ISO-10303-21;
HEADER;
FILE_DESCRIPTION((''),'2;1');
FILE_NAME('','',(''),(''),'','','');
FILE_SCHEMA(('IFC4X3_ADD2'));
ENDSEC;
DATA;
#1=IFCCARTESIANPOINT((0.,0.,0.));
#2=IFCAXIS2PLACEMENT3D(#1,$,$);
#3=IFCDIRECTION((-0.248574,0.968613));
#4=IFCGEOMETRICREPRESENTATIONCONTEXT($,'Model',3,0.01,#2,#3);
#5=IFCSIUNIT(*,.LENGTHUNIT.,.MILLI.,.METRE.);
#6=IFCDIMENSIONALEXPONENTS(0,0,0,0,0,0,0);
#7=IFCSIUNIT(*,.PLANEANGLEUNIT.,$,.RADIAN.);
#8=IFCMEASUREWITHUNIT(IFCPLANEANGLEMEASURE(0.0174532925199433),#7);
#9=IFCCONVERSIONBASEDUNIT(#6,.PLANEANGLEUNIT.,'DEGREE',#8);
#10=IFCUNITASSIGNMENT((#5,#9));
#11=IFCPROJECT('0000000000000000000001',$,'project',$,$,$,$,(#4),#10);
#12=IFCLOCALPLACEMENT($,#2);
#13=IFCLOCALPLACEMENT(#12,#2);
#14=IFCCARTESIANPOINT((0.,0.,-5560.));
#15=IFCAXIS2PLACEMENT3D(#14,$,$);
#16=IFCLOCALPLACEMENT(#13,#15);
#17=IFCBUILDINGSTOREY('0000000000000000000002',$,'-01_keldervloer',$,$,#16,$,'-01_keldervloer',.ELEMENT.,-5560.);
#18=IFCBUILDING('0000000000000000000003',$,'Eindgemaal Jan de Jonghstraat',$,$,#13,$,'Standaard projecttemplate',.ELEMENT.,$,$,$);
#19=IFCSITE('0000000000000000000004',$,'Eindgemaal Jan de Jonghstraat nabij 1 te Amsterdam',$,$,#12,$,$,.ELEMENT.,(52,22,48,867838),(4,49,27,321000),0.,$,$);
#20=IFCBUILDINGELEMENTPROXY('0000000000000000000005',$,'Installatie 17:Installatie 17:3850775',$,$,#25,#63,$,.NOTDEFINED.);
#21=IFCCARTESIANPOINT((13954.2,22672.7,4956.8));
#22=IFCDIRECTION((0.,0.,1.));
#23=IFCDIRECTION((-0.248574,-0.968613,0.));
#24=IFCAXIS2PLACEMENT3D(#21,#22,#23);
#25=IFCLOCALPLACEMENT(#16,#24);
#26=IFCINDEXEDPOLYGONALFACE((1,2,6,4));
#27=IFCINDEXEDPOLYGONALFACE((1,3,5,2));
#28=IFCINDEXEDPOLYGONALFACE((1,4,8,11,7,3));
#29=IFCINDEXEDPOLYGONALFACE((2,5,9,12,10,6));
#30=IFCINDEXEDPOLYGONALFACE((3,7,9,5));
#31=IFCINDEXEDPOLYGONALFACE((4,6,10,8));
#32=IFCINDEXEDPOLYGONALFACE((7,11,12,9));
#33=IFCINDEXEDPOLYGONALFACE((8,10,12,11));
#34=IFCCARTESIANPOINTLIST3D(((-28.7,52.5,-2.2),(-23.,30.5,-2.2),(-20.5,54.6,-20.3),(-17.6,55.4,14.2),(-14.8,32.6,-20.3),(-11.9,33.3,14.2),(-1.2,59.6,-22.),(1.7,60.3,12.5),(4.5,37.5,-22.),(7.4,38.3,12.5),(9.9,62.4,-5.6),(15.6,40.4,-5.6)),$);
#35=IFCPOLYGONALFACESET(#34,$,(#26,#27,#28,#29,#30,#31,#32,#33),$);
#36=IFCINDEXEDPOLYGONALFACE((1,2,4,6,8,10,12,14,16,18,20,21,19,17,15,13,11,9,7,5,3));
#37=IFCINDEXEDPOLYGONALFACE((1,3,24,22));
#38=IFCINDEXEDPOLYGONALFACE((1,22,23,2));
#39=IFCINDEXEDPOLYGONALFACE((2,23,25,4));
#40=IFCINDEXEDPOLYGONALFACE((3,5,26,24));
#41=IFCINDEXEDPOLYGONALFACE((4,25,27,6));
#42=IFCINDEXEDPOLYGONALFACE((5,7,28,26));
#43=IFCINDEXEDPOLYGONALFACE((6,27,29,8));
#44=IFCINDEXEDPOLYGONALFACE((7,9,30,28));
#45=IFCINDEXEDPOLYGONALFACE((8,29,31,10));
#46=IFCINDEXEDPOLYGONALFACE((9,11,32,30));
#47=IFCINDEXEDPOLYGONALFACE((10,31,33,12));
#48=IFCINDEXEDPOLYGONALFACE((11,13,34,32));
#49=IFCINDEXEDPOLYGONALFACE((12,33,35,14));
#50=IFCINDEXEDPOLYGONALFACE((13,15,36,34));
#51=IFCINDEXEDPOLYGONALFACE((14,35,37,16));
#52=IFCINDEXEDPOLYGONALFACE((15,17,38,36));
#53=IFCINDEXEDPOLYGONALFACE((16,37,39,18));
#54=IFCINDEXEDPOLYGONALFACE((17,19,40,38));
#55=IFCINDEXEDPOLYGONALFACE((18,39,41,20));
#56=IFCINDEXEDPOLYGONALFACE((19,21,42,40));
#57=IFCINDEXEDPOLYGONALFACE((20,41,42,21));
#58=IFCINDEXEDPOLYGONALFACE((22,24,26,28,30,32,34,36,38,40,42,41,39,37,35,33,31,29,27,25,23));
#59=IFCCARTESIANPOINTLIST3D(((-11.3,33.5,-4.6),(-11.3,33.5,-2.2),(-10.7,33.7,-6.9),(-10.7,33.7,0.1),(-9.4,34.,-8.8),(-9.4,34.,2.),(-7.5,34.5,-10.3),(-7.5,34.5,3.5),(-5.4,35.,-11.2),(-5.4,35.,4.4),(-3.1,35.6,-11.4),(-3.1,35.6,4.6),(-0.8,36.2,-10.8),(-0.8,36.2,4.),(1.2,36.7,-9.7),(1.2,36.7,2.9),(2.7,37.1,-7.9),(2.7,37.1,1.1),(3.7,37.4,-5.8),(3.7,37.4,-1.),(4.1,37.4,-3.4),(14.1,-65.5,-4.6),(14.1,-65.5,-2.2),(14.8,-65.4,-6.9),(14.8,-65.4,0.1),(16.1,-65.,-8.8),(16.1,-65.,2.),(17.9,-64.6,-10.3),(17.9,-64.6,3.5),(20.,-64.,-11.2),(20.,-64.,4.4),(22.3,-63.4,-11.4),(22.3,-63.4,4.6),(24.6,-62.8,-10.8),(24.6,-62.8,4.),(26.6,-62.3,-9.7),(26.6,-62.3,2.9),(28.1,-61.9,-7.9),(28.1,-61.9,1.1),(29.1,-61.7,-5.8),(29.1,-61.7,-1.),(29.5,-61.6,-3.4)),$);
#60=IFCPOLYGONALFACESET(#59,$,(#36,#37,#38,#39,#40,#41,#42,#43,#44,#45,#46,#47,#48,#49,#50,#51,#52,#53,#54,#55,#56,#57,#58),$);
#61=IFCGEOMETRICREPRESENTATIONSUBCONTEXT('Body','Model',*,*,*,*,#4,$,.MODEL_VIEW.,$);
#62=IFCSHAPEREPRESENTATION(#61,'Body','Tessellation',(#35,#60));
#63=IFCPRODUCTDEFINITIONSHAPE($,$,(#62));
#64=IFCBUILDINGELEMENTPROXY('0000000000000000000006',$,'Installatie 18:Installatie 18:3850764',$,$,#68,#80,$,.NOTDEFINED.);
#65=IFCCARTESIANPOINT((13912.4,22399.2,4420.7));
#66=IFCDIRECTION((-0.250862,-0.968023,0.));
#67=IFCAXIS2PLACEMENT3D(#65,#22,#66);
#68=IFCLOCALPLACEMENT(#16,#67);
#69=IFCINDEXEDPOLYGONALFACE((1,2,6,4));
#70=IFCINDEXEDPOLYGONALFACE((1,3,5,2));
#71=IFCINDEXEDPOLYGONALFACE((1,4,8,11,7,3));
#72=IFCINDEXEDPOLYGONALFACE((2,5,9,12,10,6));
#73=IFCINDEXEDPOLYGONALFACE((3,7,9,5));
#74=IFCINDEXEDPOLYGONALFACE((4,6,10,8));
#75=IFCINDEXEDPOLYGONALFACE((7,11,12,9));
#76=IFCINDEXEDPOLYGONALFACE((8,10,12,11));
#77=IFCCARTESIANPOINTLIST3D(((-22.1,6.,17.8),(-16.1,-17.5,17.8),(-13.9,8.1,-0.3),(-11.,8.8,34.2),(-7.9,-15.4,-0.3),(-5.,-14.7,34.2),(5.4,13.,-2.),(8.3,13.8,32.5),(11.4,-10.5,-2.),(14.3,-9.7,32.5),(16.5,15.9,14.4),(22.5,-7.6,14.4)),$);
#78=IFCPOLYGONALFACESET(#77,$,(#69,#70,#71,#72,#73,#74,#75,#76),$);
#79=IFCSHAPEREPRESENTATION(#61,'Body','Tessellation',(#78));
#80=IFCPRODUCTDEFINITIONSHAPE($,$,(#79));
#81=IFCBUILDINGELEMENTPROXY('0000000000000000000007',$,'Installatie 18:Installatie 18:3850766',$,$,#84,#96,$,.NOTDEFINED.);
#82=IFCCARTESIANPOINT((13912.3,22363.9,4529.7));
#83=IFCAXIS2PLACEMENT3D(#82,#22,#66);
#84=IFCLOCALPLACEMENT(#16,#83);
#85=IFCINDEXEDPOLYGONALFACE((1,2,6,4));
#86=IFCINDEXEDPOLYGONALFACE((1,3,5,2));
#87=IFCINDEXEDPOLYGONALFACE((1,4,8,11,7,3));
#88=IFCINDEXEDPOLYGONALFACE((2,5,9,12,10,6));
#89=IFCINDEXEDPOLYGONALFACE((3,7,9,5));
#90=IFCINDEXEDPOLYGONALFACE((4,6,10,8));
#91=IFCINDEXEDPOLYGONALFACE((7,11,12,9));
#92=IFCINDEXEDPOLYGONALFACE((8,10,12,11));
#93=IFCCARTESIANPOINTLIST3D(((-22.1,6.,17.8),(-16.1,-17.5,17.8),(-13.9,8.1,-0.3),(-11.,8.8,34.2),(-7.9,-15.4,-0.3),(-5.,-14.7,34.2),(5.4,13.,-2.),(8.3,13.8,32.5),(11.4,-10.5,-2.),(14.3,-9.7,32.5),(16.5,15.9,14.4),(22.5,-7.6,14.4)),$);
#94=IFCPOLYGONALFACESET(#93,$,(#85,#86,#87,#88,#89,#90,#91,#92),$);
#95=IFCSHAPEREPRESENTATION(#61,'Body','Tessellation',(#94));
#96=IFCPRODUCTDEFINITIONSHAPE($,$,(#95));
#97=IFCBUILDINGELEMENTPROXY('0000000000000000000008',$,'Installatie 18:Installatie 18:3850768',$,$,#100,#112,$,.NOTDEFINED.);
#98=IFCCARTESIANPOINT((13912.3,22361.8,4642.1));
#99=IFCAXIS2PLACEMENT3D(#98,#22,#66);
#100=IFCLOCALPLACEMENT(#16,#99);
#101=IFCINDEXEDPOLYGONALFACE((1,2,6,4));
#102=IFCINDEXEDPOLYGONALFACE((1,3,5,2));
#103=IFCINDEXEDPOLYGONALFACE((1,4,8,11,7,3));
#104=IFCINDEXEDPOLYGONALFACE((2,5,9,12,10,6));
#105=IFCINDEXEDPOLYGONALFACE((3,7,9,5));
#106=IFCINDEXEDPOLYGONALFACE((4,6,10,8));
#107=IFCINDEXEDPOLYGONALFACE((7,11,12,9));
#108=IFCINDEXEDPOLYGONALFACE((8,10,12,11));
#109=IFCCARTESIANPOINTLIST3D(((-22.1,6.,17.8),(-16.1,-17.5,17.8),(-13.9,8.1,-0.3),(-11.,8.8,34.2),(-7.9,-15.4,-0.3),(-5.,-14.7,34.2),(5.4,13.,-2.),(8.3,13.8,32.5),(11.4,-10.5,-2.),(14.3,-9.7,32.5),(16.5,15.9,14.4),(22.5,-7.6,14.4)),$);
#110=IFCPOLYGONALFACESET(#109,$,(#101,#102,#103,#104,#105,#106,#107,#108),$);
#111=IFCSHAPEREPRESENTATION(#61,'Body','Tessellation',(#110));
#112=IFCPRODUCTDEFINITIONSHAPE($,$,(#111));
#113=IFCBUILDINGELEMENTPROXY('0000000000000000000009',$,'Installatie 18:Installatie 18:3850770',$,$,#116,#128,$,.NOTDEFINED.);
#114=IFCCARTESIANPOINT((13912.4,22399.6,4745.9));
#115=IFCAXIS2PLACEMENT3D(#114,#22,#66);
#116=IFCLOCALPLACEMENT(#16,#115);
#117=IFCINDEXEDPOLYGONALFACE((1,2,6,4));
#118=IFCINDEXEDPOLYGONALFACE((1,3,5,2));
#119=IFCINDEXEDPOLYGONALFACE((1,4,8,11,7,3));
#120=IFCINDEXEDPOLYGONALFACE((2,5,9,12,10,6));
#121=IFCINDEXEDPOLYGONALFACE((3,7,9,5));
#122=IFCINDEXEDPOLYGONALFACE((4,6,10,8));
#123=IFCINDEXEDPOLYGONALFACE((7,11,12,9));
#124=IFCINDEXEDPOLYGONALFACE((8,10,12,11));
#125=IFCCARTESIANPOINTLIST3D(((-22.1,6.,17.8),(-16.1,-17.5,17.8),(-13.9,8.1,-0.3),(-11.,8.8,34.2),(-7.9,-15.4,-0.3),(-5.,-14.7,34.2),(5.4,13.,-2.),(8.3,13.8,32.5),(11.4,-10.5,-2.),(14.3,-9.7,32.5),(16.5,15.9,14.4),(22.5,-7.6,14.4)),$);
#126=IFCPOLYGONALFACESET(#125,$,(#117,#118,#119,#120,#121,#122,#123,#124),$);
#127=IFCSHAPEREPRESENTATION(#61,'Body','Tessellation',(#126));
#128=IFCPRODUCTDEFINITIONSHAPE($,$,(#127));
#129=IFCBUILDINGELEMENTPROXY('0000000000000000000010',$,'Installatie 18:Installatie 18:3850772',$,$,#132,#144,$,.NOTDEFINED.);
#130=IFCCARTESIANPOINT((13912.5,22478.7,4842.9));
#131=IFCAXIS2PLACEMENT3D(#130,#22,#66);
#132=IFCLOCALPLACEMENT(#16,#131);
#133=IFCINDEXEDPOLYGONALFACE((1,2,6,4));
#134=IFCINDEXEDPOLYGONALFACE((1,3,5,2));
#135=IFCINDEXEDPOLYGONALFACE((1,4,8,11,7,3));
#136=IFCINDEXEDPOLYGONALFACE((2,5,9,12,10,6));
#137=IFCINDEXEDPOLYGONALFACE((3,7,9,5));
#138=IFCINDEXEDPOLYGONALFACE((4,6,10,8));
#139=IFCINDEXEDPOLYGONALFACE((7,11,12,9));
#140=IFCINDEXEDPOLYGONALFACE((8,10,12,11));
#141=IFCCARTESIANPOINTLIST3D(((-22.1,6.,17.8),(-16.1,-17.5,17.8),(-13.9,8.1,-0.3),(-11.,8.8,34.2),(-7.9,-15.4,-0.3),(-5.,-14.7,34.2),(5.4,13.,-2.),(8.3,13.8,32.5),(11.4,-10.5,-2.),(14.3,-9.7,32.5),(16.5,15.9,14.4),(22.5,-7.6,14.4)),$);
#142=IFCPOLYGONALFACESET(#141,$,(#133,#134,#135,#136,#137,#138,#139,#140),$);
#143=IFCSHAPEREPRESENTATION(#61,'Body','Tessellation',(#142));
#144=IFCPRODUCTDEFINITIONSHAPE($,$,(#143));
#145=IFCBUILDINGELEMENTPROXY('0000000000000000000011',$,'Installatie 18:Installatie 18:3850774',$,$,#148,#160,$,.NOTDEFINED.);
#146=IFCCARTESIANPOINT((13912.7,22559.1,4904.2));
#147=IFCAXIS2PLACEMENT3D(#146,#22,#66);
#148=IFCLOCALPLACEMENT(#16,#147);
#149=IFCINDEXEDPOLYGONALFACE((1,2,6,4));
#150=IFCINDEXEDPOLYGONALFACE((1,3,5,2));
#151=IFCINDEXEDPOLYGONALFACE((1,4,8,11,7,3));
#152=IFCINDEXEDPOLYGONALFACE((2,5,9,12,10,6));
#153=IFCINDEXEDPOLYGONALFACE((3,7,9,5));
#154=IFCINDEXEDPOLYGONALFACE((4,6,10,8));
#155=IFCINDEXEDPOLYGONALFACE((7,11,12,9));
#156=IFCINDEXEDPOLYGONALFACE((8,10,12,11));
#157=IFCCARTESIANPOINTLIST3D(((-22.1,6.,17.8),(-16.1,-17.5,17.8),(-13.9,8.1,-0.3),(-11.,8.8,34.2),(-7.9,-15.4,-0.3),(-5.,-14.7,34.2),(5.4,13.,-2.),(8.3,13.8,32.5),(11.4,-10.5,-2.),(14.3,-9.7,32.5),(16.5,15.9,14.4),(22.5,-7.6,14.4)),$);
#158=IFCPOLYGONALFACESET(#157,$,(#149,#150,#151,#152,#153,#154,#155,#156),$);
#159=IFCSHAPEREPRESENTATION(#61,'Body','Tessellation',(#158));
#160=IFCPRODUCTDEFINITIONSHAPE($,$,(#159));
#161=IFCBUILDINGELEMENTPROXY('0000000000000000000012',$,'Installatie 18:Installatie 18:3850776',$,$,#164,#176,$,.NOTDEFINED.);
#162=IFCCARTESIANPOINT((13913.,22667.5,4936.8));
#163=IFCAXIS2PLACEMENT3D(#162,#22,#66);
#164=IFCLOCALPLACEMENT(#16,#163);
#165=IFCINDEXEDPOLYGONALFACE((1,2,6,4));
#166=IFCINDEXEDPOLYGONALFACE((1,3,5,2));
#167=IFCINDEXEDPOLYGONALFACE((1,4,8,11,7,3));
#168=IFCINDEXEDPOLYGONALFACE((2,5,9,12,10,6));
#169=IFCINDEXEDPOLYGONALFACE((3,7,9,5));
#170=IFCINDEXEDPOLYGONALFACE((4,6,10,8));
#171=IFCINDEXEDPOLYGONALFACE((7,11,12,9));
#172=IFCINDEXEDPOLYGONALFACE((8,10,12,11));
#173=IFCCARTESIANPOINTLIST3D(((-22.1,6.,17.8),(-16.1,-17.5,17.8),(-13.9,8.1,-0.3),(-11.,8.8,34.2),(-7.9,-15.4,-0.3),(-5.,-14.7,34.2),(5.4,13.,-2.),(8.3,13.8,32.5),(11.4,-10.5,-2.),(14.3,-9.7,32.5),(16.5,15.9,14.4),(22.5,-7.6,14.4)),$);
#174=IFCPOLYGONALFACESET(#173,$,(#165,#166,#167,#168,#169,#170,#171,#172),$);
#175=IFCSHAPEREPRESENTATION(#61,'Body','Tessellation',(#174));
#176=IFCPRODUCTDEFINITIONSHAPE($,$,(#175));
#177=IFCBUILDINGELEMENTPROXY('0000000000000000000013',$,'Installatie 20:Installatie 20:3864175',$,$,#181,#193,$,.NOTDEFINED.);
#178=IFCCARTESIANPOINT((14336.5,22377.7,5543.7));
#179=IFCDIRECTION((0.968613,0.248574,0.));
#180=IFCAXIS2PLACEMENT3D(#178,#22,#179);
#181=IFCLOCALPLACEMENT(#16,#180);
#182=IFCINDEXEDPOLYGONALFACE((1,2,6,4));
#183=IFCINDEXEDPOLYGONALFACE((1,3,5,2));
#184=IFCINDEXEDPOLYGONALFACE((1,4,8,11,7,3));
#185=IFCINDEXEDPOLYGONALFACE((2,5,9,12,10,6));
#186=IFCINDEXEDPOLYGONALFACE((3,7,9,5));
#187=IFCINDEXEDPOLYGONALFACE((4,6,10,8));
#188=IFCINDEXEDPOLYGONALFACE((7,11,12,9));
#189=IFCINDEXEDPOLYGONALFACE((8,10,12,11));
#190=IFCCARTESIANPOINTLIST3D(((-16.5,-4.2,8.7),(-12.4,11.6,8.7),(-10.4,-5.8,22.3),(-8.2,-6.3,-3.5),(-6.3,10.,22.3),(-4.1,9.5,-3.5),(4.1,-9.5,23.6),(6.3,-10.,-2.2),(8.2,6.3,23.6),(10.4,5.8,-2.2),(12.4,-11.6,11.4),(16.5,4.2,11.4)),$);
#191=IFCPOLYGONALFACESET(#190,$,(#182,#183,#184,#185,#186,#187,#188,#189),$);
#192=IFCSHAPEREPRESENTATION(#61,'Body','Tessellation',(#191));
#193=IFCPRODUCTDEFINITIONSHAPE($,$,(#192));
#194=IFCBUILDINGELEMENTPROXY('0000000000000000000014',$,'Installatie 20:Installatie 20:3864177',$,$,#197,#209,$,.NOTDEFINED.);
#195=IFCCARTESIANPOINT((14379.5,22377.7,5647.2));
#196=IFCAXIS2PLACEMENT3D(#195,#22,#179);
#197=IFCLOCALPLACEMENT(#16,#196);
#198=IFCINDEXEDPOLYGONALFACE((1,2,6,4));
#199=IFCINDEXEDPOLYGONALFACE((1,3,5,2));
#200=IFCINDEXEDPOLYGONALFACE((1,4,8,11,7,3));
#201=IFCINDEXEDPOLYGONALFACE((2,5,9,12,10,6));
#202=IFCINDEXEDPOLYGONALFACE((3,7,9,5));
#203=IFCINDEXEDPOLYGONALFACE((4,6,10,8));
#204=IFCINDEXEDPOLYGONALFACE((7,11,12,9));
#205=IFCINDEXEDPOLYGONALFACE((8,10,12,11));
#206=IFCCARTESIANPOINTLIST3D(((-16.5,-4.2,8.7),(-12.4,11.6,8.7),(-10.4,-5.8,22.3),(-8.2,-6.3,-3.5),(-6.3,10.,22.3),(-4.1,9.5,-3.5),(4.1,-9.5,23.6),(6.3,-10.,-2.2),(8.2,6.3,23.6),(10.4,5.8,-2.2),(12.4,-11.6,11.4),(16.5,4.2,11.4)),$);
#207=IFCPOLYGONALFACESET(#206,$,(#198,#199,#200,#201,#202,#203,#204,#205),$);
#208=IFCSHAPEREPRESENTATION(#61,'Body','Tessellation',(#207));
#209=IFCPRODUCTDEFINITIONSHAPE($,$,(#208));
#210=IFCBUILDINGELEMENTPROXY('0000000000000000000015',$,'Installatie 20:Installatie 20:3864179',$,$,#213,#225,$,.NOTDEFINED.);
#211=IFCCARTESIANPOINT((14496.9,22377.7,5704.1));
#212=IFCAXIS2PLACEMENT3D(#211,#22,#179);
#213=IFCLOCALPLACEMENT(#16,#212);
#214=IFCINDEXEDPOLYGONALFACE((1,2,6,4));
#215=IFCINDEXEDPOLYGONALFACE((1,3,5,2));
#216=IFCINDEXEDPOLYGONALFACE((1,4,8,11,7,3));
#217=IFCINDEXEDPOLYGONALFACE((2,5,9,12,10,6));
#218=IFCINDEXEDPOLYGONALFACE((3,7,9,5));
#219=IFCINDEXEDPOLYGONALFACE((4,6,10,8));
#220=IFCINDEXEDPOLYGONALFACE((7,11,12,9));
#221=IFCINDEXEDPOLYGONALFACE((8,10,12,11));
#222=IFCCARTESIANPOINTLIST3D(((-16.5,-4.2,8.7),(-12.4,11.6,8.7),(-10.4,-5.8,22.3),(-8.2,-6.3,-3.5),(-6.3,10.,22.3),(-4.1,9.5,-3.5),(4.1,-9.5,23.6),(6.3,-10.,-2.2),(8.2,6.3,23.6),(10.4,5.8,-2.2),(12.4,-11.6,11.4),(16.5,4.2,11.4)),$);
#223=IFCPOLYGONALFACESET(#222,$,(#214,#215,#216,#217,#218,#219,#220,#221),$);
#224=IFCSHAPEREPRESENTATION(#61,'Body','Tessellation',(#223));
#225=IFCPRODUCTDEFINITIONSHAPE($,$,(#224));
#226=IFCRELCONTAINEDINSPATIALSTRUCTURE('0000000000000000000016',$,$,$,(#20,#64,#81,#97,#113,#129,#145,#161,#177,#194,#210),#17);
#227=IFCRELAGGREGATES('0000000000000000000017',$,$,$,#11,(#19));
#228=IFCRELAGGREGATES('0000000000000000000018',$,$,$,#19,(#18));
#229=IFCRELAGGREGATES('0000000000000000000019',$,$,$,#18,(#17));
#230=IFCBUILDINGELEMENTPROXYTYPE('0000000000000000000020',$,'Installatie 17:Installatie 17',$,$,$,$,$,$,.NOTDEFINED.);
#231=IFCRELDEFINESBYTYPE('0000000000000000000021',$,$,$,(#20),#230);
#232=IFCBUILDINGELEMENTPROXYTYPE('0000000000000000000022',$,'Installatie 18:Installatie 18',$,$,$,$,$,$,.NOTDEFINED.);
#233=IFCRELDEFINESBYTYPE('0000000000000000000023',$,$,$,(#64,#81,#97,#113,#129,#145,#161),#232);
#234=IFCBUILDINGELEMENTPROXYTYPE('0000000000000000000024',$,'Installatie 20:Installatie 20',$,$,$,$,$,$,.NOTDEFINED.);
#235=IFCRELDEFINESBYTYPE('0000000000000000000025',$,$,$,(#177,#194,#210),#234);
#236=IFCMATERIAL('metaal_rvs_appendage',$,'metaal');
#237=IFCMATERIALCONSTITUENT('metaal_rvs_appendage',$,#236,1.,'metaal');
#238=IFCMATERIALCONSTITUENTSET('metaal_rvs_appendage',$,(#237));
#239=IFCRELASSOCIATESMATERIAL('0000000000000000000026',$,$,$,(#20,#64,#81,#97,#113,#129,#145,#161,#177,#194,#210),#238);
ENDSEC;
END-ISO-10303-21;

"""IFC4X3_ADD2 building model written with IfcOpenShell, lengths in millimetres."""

from ifc_helpers import new_model, entity, si_unit, converted_unit, direction, frame, frame_2d, origin, place, context, subcontext, project, spatial, polyline, circle, outline, extrude, source, transform, mapped, material, constituent, constituent_set, type_object, type_shapes, element, save


model = new_model("IFC4X3_ADD2")

# Units and contexts
model_context = context("Model", 3, precision=0.01, world=origin(), true_north=direction((-0.248574, 0.968613)))
body_context = subcontext(model_context, "Body", "Model", "MODEL_VIEW")
ifc_project = project(units=[si_unit("LENGTHUNIT", "METRE", prefix="MILLI"), converted_unit("PLANEANGLEUNIT", "DEGREE", entity("IfcPlaneAngleMeasure", 0.0174532925199433), si_unit("PLANEANGLEUNIT", "RADIAN"), dimensions=[0, 0, 0, 0, 0, 0, 0])], contexts=[model_context])

# Site, building, storey
site_placement = place(None, origin())
site = spatial("IfcSite", under=ifc_project, at=site_placement, Name="Eindgemaal Jan de Jonghstraat nabij 1 te Amsterdam", CompositionType="ELEMENT", RefLatitude=(52, 22, 48, 867838), RefLongitude=(4, 49, 27, 321000), RefElevation=0.0)
building_placement = place(site_placement, origin())
building = spatial("IfcBuilding", under=site, at=building_placement, Name="Eindgemaal Jan de Jonghstraat", LongName="Standaard projecttemplate", CompositionType="ELEMENT")
storey_placement = place(building_placement, frame((0.0, 0.0, -5560.0)))
storey = spatial("IfcBuildingStorey", under=building, at=storey_placement, Name="-01_keldervloer", LongName="-01_keldervloer", CompositionType="ELEMENT", Elevation=-5560.0)

# Building element proxies
ifc_material_1 = material(Name="metaal_rvs_appendage", Category="metaal")
ifc_constituent_1 = constituent(ifc_material_1, Name="metaal_rvs_appendage", Category="metaal", fraction=1.0)
ifc_constituent_set_1 = constituent_set(constituents=[ifc_constituent_1], Name="metaal_rvs_appendage")
building_element_proxy_type_1 = type_object("IfcBuildingElementProxyType", Name="Installatie 17:Installatie 17", PredefinedType="NOTDEFINED")
shared_shape_1 = source(origin(), body_context, "Body", "SweptSolid", [
    extrude(outline(polyline([(-10.0, -17.3), (10.0, -17.3), (20.0, 0.0), (10.0, 17.3), (-10.0, 17.3), (-20.0, 0.0), (-10.0, -17.3)])), frame((-3.7, 35.4, -3.9), z_axis=(-0.248574, 0.968613, 0.0), x_axis=(-0.555573, -0.142576, -0.819152)), (0.0, 0.0, 1.0), 22.8),
    extrude(circle(Radius=8.0, at=frame_2d((0.0, 0.0), x_axis=(1.0, 0.0))), frame((21.7, -63.6, -3.4), z_axis=(-0.248574, 0.968613, 0.0), x_axis=(0.968613, 0.248574, 0.0)), (0.0, 0.0, 1.0), 102.2),
])
type_shapes(building_element_proxy_type_1, [shared_shape_1])
for number, where, z_axis, x_axis, name in (
    (1, (13954.2, 22672.7, 4956.8), (0.0, 0.0, 1.0), (-0.248574, -0.968613, 0.0), "Installatie 17:Installatie 17:3850775"),
):
    element("IfcBuildingElementProxy", number, at=place(storey_placement, frame(where, z_axis=z_axis, x_axis=x_axis)), inside=storey, type_object=building_element_proxy_type_1, material=ifc_constituent_set_1, Name=name, PredefinedType="NOTDEFINED", context=body_context, shape_type="MappedRepresentation", body=[
        mapped(shared_shape_1, transform((0.0, 0.0, 0.0), scale=1.0)),
    ])
building_element_proxy_type_2 = type_object("IfcBuildingElementProxyType", Name="Installatie 18:Installatie 18", PredefinedType="NOTDEFINED")
shared_shape_2 = source(origin(), body_context, "Body", "SweptSolid", [
    extrude(outline(polyline([(-10.0, -17.3), (10.0, -17.3), (20.0, 0.0), (10.0, 17.3), (-10.0, 17.3), (-20.0, 0.0), (-10.0, -17.3)])), frame((3.2, -12.6, 16.1), z_axis=(-0.248574, 0.968613, 0.0), x_axis=(0.409353, 0.105052, -0.906308)), (0.0, 0.0, 1.0), 24.3),
])
type_shapes(building_element_proxy_type_2, [shared_shape_2])
for number, where, z_axis, x_axis, name in (
    (2, (13912.4, 22399.2, 4420.7), (0.0, 0.0, 1.0), (-0.250862, -0.968023, 0.0), "Installatie 18:Installatie 18:3850764"),
    (3, (13912.3, 22363.9, 4529.7), (0.0, 0.0, 1.0), (-0.250862, -0.968023, 0.0), "Installatie 18:Installatie 18:3850766"),
    (4, (13912.3, 22361.8, 4642.1), (0.0, 0.0, 1.0), (-0.250862, -0.968023, 0.0), "Installatie 18:Installatie 18:3850768"),
    (5, (13912.4, 22399.6, 4745.9), (0.0, 0.0, 1.0), (-0.250862, -0.968023, 0.0), "Installatie 18:Installatie 18:3850770"),
    (6, (13912.5, 22478.7, 4842.9), (0.0, 0.0, 1.0), (-0.250862, -0.968023, 0.0), "Installatie 18:Installatie 18:3850772"),
    (7, (13912.7, 22559.1, 4904.2), (0.0, 0.0, 1.0), (-0.250862, -0.968023, 0.0), "Installatie 18:Installatie 18:3850774"),
    (8, (13913.0, 22667.5, 4936.8), (0.0, 0.0, 1.0), (-0.250862, -0.968023, 0.0), "Installatie 18:Installatie 18:3850776"),
):
    element("IfcBuildingElementProxy", number, at=place(storey_placement, frame(where, z_axis=z_axis, x_axis=x_axis)), inside=storey, type_object=building_element_proxy_type_2, material=ifc_constituent_set_1, Name=name, PredefinedType="NOTDEFINED", context=body_context, shape_type="MappedRepresentation", body=[
        mapped(shared_shape_2, transform((0.0, 0.0, 0.0), scale=1.0)),
    ])
building_element_proxy_type_3 = type_object("IfcBuildingElementProxyType", Name="Installatie 20:Installatie 20", PredefinedType="NOTDEFINED")
shared_shape_3 = source(origin(), body_context, "Body", "SweptSolid", [
    extrude(outline(polyline([(-7.5, -13.0), (7.5, -13.0), (15.0, 0.0), (7.5, 13.0), (-7.5, 13.0), (-15.0, 0.0), (-7.5, -13.0)])), frame((-2.0, -7.9, 10.0), z_axis=(0.248574, 0.968613, 0.0), x_axis=(0.964927, -0.247628, 0.087156)), (0.0, 0.0, 1.0), 16.3),
])
type_shapes(building_element_proxy_type_3, [shared_shape_3])
for number, where, z_axis, x_axis, name in (
    (9, (14336.5, 22377.7, 5543.7), (0.0, 0.0, 1.0), (0.968613, 0.248574, 0.0), "Installatie 20:Installatie 20:3864175"),
    (10, (14379.5, 22377.7, 5647.2), (0.0, 0.0, 1.0), (0.968613, 0.248574, 0.0), "Installatie 20:Installatie 20:3864177"),
    (11, (14496.9, 22377.7, 5704.1), (0.0, 0.0, 1.0), (0.968613, 0.248574, 0.0), "Installatie 20:Installatie 20:3864179"),
):
    element("IfcBuildingElementProxy", number, at=place(storey_placement, frame(where, z_axis=z_axis, x_axis=x_axis)), inside=storey, type_object=building_element_proxy_type_3, material=ifc_constituent_set_1, Name=name, PredefinedType="NOTDEFINED", context=body_context, shape_type="MappedRepresentation", body=[
        mapped(shared_shape_3, transform((0.0, 0.0, 0.0), scale=1.0)),
    ])

save(model, "model.ifc")
